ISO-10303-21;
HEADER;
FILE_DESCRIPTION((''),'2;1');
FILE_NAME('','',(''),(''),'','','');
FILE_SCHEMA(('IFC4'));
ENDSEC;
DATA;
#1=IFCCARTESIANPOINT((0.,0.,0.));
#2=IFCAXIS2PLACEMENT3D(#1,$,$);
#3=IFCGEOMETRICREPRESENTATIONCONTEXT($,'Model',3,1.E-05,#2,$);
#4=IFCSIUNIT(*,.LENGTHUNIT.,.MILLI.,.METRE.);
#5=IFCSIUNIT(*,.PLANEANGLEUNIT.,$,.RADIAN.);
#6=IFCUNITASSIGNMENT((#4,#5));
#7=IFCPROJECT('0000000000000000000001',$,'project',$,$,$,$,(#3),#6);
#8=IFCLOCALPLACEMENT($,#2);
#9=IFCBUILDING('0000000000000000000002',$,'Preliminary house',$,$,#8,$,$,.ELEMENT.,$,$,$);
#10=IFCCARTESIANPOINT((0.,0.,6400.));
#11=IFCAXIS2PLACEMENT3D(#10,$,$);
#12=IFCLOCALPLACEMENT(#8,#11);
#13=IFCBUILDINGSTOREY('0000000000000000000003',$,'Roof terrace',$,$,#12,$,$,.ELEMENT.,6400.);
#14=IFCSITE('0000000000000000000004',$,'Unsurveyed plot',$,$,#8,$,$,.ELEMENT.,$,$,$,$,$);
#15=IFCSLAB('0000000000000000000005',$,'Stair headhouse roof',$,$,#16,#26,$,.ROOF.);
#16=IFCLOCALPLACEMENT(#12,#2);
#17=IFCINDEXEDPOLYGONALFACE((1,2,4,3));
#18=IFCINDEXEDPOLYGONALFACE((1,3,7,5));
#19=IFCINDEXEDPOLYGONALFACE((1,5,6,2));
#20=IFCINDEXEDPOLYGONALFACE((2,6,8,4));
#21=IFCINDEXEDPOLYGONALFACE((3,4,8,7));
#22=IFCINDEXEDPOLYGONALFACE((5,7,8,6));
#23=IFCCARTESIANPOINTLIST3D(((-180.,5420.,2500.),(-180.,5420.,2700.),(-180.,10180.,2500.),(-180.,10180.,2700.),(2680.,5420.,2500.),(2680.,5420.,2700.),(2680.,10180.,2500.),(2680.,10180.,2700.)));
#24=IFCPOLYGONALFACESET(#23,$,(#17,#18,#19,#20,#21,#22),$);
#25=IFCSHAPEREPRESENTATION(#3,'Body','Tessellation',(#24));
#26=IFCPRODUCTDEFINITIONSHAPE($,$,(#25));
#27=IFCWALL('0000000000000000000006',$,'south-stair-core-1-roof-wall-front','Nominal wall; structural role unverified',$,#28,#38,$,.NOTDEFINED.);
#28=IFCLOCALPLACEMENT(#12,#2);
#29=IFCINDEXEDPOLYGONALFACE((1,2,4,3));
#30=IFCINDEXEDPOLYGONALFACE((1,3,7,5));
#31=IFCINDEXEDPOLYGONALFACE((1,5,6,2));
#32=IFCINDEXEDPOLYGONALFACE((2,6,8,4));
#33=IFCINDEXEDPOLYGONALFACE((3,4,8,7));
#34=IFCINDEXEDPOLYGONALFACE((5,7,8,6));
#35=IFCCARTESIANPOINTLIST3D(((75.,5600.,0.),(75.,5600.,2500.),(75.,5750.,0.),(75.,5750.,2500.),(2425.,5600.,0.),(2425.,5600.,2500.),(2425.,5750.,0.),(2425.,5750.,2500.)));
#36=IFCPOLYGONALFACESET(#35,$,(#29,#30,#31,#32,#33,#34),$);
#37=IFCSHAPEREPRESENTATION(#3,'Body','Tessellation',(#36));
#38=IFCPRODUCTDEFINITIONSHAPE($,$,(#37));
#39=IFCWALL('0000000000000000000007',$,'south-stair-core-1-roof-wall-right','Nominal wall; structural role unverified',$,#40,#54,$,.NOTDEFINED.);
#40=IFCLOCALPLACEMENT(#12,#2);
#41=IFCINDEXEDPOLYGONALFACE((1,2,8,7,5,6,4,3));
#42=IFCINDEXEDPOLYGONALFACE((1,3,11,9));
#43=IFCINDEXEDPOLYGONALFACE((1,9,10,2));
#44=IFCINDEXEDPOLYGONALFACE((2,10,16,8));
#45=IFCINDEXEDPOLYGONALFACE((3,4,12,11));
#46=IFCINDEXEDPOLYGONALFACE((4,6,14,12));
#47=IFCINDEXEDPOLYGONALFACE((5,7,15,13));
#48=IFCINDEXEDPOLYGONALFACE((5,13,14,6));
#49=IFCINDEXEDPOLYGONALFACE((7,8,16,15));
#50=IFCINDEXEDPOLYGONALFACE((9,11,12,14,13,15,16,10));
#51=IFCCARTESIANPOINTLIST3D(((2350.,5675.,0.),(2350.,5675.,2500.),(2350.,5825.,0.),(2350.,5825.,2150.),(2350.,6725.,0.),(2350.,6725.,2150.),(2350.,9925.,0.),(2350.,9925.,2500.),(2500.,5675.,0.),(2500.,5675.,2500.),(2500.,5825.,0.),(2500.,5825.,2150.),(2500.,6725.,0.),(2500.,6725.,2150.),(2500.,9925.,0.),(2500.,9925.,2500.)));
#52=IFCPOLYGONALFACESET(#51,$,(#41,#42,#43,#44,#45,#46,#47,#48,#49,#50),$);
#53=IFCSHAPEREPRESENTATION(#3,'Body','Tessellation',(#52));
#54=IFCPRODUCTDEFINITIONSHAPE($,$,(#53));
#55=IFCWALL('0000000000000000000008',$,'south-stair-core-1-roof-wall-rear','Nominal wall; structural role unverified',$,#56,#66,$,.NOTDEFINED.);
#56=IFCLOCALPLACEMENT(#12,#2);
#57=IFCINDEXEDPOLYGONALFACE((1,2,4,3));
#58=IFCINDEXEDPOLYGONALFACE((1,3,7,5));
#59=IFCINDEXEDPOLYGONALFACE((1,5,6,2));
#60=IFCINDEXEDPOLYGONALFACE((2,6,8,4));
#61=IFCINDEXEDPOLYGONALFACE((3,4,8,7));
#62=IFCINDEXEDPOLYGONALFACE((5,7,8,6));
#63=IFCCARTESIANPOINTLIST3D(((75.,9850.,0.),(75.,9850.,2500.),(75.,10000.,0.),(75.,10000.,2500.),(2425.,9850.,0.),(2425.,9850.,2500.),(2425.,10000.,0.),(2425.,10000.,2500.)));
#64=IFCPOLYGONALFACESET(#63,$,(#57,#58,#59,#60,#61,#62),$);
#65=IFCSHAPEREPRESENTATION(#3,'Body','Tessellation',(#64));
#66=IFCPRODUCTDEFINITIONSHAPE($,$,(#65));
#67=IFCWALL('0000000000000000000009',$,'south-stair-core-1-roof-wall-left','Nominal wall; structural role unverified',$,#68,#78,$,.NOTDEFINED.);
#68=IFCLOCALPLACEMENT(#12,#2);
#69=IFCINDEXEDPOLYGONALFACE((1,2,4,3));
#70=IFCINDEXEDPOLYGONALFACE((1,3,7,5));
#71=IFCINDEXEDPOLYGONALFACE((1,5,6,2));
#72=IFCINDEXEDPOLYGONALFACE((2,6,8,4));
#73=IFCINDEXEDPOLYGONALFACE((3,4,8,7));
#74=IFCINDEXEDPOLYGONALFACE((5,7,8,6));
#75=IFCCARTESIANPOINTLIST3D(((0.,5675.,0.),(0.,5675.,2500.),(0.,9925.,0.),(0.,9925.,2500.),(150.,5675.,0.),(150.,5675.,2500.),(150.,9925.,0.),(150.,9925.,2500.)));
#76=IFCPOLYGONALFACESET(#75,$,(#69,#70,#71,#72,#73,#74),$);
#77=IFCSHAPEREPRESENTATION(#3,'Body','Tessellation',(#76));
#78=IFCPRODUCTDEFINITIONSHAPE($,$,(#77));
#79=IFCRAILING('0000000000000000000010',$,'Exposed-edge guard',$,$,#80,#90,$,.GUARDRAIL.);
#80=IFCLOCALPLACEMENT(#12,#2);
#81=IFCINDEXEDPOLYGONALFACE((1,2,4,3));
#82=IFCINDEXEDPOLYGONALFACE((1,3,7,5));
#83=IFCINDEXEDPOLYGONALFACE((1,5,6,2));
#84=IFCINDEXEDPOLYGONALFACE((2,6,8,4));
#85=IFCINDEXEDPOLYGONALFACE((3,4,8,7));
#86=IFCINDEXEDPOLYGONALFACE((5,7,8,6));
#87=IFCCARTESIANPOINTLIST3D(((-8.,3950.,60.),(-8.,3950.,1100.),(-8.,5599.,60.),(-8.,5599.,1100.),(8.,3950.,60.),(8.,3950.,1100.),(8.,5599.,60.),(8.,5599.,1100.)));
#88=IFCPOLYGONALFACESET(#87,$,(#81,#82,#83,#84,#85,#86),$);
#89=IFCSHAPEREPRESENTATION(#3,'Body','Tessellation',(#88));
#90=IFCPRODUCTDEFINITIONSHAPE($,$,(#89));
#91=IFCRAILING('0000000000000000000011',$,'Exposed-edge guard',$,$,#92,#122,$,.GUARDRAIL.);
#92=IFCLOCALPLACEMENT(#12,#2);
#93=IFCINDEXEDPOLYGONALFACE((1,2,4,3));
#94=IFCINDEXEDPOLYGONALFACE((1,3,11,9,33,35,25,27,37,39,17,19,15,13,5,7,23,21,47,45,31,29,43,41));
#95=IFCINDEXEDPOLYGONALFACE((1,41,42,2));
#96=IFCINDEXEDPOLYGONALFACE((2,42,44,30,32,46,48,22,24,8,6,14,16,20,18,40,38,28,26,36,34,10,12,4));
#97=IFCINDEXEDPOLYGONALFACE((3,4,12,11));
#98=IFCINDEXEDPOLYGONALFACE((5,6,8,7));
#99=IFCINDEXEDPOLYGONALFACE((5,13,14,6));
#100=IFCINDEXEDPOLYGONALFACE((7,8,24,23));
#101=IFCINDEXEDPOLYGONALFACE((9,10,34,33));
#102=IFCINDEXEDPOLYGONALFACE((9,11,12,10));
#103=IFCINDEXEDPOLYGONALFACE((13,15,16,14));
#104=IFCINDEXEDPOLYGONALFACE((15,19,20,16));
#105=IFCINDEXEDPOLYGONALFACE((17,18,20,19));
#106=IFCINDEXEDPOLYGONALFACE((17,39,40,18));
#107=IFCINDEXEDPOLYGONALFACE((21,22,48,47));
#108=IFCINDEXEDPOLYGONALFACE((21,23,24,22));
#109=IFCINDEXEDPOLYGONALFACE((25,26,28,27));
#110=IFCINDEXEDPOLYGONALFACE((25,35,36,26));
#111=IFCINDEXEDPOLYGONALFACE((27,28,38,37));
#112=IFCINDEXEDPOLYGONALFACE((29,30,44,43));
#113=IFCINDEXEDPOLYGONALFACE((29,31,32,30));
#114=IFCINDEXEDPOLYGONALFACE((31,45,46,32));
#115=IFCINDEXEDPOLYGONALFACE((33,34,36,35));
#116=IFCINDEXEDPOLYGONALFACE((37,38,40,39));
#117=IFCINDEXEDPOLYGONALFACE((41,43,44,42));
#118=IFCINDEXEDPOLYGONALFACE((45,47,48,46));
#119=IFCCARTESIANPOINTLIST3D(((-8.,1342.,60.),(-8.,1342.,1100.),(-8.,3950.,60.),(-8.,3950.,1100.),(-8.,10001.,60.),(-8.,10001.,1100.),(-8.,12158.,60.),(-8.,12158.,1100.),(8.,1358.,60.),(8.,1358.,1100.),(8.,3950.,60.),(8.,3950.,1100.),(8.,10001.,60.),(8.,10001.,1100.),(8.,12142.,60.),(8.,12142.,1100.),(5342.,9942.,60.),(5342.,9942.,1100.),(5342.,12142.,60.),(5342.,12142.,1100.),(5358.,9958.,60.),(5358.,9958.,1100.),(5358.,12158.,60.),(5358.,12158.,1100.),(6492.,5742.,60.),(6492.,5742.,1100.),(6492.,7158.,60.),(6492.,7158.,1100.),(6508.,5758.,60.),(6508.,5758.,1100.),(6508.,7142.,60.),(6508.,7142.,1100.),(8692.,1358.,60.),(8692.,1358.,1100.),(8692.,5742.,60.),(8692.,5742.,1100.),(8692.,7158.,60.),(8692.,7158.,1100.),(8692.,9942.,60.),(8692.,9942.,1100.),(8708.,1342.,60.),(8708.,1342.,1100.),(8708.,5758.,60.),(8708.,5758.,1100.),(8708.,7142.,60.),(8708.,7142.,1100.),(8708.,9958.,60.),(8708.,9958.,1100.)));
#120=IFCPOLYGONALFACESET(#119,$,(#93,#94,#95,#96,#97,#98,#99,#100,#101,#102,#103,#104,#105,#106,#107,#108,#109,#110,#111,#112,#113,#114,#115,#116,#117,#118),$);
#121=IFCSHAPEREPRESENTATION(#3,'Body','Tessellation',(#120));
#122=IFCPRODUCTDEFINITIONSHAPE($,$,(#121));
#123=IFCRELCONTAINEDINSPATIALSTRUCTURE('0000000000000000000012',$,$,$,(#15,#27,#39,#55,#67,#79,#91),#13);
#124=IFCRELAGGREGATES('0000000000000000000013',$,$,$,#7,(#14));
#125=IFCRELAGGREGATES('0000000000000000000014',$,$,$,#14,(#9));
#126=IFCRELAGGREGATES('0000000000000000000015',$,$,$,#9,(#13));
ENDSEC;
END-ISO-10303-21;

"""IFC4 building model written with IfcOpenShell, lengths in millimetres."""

from ifc_helpers import new_model, si_unit, frame, origin, place, context, project, spatial, polyline, outline, extrude, element, save


model = new_model("IFC4")

# Units and contexts
model_context = context("Model", 3, precision=1e-05, world=origin())
ifc_project = project(units=[si_unit("LENGTHUNIT", "METRE", prefix="MILLI"), si_unit("PLANEANGLEUNIT", "RADIAN")], contexts=[model_context])

# Site, building, storey
placement_1 = place(None, origin())
site = spatial("IfcSite", under=ifc_project, at=placement_1, Name="Unsurveyed plot", CompositionType="ELEMENT")
building = spatial("IfcBuilding", under=site, at=placement_1, Name="Preliminary house", CompositionType="ELEMENT")
placement_2 = place(placement_1, frame((0.0, 0.0, 6400.0)))
storey = spatial("IfcBuildingStorey", under=building, at=placement_2, Name="Roof terrace", CompositionType="ELEMENT", Elevation=6400.0)

# Slab
element("IfcSlab", 1, at=placement_2, inside=storey, Name="Stair headhouse roof", PredefinedType="ROOF", context=model_context, shape_type="SweptSolid", body=[
    extrude(outline(polyline([(2680.0, 5420.0), (-180.0, 5420.0), (-180.0, 10180.0), (2680.0, 10180.0), (2680.0, 5420.0)])), frame((0.0, 0.0, 2500.0)), (0.0, 0.0, 1.0), 200.0),
])

# Wall
element("IfcWall", 2, at=placement_2, inside=storey, Name="south-stair-core-1-roof-wall-front", Description="Nominal wall; structural role unverified", PredefinedType="NOTDEFINED", context=model_context, shape_type="SweptSolid", body=[
    extrude(outline(polyline([(2425.0, 5750.0), (2425.0, 5600.0), (75.0, 5600.0), (75.0, 5750.0), (2425.0, 5750.0)])), origin(), (0.0, 0.0, 1.0), 2500.0),
])

# Wall, opening
wall_1 = element("IfcWall", 3, at=placement_2, inside=storey, Name="south-stair-core-1-roof-wall-right", Description="Nominal wall; structural role unverified", PredefinedType="NOTDEFINED", context=model_context, shape_type="SweptSolid", body=[
    extrude(outline(polyline([(2350.0, 9925.0), (2500.0, 9925.0), (2500.0, 5675.0), (2350.0, 5675.0), (2350.0, 9925.0)])), origin(), (0.0, 0.0, 1.0), 2500.0),
])
element("IfcOpeningElement", 4, at=placement_2, cuts=wall_1, PredefinedType="OPENING", context=model_context, shape_type="SweptSolid", body=[
    extrude(outline(polyline([(2875.0, 5825.0), (2875.0, 6725.0), (1975.0, 6725.0), (1975.0, 5825.0), (2875.0, 5825.0)])), origin(), (0.0, 0.0, 1.0), 2150.0),
])

# Walls
element("IfcWall", 5, at=placement_2, inside=storey, Name="south-stair-core-1-roof-wall-rear", Description="Nominal wall; structural role unverified", PredefinedType="NOTDEFINED", context=model_context, shape_type="SweptSolid", body=[
    extrude(outline(polyline([(2425.0, 10000.0), (2425.0, 9850.0), (75.0, 9850.0), (75.0, 10000.0), (2425.0, 10000.0)])), origin(), (0.0, 0.0, 1.0), 2500.0),
])
element("IfcWall", 6, at=placement_2, inside=storey, Name="south-stair-core-1-roof-wall-left", Description="Nominal wall; structural role unverified", PredefinedType="NOTDEFINED", context=model_context, shape_type="SweptSolid", body=[
    extrude(outline(polyline([(0.0, 9925.0), (150.0, 9925.0), (150.0, 5675.0), (0.0, 5675.0), (0.0, 9925.0)])), origin(), (0.0, 0.0, 1.0), 2500.0),
])

# Railings
element("IfcRailing", 7, at=placement_2, inside=storey, Name="Exposed-edge guard", PredefinedType="GUARDRAIL", context=model_context, shape_type="SweptSolid", body=[
    extrude(outline(polyline([(-8.0, 5599.0), (8.0, 5599.0), (8.0, 3950.0), (-8.0, 3950.0), (-8.0, 5599.0)])), frame((0.0, 0.0, 60.0)), (0.0, 0.0, 1.0), 1040.0),
])
element("IfcRailing", 8, at=placement_2, inside=storey, Name="Exposed-edge guard", PredefinedType="GUARDRAIL", context=model_context, shape_type="SweptSolid", body=[
    extrude(outline(polyline([(-8.0, 12158.0), (5358.0, 12158.0), (5358.0, 9958.0), (8708.0, 9958.0), (8708.0, 7142.0), (6508.0, 7142.0), (6508.0, 5758.0), (8708.0, 5758.0), (8708.0, 1342.0), (-8.0, 1342.0), (-8.0, 3950.0), (8.0, 3950.0), (8.0, 1358.0), (8692.0, 1358.0), (8692.0, 5742.0), (6492.0, 5742.0), (6492.0, 7158.0), (8692.0, 7158.0), (8692.0, 9942.0), (5342.0, 9942.0), (5342.0, 12142.0), (8.0, 12142.0), (8.0, 10001.0), (-8.0, 10001.0), (-8.0, 12158.0)])), frame((0.0, 0.0, 60.0)), (0.0, 0.0, 1.0), 1040.0),
])

save(model, "model.ifc")
